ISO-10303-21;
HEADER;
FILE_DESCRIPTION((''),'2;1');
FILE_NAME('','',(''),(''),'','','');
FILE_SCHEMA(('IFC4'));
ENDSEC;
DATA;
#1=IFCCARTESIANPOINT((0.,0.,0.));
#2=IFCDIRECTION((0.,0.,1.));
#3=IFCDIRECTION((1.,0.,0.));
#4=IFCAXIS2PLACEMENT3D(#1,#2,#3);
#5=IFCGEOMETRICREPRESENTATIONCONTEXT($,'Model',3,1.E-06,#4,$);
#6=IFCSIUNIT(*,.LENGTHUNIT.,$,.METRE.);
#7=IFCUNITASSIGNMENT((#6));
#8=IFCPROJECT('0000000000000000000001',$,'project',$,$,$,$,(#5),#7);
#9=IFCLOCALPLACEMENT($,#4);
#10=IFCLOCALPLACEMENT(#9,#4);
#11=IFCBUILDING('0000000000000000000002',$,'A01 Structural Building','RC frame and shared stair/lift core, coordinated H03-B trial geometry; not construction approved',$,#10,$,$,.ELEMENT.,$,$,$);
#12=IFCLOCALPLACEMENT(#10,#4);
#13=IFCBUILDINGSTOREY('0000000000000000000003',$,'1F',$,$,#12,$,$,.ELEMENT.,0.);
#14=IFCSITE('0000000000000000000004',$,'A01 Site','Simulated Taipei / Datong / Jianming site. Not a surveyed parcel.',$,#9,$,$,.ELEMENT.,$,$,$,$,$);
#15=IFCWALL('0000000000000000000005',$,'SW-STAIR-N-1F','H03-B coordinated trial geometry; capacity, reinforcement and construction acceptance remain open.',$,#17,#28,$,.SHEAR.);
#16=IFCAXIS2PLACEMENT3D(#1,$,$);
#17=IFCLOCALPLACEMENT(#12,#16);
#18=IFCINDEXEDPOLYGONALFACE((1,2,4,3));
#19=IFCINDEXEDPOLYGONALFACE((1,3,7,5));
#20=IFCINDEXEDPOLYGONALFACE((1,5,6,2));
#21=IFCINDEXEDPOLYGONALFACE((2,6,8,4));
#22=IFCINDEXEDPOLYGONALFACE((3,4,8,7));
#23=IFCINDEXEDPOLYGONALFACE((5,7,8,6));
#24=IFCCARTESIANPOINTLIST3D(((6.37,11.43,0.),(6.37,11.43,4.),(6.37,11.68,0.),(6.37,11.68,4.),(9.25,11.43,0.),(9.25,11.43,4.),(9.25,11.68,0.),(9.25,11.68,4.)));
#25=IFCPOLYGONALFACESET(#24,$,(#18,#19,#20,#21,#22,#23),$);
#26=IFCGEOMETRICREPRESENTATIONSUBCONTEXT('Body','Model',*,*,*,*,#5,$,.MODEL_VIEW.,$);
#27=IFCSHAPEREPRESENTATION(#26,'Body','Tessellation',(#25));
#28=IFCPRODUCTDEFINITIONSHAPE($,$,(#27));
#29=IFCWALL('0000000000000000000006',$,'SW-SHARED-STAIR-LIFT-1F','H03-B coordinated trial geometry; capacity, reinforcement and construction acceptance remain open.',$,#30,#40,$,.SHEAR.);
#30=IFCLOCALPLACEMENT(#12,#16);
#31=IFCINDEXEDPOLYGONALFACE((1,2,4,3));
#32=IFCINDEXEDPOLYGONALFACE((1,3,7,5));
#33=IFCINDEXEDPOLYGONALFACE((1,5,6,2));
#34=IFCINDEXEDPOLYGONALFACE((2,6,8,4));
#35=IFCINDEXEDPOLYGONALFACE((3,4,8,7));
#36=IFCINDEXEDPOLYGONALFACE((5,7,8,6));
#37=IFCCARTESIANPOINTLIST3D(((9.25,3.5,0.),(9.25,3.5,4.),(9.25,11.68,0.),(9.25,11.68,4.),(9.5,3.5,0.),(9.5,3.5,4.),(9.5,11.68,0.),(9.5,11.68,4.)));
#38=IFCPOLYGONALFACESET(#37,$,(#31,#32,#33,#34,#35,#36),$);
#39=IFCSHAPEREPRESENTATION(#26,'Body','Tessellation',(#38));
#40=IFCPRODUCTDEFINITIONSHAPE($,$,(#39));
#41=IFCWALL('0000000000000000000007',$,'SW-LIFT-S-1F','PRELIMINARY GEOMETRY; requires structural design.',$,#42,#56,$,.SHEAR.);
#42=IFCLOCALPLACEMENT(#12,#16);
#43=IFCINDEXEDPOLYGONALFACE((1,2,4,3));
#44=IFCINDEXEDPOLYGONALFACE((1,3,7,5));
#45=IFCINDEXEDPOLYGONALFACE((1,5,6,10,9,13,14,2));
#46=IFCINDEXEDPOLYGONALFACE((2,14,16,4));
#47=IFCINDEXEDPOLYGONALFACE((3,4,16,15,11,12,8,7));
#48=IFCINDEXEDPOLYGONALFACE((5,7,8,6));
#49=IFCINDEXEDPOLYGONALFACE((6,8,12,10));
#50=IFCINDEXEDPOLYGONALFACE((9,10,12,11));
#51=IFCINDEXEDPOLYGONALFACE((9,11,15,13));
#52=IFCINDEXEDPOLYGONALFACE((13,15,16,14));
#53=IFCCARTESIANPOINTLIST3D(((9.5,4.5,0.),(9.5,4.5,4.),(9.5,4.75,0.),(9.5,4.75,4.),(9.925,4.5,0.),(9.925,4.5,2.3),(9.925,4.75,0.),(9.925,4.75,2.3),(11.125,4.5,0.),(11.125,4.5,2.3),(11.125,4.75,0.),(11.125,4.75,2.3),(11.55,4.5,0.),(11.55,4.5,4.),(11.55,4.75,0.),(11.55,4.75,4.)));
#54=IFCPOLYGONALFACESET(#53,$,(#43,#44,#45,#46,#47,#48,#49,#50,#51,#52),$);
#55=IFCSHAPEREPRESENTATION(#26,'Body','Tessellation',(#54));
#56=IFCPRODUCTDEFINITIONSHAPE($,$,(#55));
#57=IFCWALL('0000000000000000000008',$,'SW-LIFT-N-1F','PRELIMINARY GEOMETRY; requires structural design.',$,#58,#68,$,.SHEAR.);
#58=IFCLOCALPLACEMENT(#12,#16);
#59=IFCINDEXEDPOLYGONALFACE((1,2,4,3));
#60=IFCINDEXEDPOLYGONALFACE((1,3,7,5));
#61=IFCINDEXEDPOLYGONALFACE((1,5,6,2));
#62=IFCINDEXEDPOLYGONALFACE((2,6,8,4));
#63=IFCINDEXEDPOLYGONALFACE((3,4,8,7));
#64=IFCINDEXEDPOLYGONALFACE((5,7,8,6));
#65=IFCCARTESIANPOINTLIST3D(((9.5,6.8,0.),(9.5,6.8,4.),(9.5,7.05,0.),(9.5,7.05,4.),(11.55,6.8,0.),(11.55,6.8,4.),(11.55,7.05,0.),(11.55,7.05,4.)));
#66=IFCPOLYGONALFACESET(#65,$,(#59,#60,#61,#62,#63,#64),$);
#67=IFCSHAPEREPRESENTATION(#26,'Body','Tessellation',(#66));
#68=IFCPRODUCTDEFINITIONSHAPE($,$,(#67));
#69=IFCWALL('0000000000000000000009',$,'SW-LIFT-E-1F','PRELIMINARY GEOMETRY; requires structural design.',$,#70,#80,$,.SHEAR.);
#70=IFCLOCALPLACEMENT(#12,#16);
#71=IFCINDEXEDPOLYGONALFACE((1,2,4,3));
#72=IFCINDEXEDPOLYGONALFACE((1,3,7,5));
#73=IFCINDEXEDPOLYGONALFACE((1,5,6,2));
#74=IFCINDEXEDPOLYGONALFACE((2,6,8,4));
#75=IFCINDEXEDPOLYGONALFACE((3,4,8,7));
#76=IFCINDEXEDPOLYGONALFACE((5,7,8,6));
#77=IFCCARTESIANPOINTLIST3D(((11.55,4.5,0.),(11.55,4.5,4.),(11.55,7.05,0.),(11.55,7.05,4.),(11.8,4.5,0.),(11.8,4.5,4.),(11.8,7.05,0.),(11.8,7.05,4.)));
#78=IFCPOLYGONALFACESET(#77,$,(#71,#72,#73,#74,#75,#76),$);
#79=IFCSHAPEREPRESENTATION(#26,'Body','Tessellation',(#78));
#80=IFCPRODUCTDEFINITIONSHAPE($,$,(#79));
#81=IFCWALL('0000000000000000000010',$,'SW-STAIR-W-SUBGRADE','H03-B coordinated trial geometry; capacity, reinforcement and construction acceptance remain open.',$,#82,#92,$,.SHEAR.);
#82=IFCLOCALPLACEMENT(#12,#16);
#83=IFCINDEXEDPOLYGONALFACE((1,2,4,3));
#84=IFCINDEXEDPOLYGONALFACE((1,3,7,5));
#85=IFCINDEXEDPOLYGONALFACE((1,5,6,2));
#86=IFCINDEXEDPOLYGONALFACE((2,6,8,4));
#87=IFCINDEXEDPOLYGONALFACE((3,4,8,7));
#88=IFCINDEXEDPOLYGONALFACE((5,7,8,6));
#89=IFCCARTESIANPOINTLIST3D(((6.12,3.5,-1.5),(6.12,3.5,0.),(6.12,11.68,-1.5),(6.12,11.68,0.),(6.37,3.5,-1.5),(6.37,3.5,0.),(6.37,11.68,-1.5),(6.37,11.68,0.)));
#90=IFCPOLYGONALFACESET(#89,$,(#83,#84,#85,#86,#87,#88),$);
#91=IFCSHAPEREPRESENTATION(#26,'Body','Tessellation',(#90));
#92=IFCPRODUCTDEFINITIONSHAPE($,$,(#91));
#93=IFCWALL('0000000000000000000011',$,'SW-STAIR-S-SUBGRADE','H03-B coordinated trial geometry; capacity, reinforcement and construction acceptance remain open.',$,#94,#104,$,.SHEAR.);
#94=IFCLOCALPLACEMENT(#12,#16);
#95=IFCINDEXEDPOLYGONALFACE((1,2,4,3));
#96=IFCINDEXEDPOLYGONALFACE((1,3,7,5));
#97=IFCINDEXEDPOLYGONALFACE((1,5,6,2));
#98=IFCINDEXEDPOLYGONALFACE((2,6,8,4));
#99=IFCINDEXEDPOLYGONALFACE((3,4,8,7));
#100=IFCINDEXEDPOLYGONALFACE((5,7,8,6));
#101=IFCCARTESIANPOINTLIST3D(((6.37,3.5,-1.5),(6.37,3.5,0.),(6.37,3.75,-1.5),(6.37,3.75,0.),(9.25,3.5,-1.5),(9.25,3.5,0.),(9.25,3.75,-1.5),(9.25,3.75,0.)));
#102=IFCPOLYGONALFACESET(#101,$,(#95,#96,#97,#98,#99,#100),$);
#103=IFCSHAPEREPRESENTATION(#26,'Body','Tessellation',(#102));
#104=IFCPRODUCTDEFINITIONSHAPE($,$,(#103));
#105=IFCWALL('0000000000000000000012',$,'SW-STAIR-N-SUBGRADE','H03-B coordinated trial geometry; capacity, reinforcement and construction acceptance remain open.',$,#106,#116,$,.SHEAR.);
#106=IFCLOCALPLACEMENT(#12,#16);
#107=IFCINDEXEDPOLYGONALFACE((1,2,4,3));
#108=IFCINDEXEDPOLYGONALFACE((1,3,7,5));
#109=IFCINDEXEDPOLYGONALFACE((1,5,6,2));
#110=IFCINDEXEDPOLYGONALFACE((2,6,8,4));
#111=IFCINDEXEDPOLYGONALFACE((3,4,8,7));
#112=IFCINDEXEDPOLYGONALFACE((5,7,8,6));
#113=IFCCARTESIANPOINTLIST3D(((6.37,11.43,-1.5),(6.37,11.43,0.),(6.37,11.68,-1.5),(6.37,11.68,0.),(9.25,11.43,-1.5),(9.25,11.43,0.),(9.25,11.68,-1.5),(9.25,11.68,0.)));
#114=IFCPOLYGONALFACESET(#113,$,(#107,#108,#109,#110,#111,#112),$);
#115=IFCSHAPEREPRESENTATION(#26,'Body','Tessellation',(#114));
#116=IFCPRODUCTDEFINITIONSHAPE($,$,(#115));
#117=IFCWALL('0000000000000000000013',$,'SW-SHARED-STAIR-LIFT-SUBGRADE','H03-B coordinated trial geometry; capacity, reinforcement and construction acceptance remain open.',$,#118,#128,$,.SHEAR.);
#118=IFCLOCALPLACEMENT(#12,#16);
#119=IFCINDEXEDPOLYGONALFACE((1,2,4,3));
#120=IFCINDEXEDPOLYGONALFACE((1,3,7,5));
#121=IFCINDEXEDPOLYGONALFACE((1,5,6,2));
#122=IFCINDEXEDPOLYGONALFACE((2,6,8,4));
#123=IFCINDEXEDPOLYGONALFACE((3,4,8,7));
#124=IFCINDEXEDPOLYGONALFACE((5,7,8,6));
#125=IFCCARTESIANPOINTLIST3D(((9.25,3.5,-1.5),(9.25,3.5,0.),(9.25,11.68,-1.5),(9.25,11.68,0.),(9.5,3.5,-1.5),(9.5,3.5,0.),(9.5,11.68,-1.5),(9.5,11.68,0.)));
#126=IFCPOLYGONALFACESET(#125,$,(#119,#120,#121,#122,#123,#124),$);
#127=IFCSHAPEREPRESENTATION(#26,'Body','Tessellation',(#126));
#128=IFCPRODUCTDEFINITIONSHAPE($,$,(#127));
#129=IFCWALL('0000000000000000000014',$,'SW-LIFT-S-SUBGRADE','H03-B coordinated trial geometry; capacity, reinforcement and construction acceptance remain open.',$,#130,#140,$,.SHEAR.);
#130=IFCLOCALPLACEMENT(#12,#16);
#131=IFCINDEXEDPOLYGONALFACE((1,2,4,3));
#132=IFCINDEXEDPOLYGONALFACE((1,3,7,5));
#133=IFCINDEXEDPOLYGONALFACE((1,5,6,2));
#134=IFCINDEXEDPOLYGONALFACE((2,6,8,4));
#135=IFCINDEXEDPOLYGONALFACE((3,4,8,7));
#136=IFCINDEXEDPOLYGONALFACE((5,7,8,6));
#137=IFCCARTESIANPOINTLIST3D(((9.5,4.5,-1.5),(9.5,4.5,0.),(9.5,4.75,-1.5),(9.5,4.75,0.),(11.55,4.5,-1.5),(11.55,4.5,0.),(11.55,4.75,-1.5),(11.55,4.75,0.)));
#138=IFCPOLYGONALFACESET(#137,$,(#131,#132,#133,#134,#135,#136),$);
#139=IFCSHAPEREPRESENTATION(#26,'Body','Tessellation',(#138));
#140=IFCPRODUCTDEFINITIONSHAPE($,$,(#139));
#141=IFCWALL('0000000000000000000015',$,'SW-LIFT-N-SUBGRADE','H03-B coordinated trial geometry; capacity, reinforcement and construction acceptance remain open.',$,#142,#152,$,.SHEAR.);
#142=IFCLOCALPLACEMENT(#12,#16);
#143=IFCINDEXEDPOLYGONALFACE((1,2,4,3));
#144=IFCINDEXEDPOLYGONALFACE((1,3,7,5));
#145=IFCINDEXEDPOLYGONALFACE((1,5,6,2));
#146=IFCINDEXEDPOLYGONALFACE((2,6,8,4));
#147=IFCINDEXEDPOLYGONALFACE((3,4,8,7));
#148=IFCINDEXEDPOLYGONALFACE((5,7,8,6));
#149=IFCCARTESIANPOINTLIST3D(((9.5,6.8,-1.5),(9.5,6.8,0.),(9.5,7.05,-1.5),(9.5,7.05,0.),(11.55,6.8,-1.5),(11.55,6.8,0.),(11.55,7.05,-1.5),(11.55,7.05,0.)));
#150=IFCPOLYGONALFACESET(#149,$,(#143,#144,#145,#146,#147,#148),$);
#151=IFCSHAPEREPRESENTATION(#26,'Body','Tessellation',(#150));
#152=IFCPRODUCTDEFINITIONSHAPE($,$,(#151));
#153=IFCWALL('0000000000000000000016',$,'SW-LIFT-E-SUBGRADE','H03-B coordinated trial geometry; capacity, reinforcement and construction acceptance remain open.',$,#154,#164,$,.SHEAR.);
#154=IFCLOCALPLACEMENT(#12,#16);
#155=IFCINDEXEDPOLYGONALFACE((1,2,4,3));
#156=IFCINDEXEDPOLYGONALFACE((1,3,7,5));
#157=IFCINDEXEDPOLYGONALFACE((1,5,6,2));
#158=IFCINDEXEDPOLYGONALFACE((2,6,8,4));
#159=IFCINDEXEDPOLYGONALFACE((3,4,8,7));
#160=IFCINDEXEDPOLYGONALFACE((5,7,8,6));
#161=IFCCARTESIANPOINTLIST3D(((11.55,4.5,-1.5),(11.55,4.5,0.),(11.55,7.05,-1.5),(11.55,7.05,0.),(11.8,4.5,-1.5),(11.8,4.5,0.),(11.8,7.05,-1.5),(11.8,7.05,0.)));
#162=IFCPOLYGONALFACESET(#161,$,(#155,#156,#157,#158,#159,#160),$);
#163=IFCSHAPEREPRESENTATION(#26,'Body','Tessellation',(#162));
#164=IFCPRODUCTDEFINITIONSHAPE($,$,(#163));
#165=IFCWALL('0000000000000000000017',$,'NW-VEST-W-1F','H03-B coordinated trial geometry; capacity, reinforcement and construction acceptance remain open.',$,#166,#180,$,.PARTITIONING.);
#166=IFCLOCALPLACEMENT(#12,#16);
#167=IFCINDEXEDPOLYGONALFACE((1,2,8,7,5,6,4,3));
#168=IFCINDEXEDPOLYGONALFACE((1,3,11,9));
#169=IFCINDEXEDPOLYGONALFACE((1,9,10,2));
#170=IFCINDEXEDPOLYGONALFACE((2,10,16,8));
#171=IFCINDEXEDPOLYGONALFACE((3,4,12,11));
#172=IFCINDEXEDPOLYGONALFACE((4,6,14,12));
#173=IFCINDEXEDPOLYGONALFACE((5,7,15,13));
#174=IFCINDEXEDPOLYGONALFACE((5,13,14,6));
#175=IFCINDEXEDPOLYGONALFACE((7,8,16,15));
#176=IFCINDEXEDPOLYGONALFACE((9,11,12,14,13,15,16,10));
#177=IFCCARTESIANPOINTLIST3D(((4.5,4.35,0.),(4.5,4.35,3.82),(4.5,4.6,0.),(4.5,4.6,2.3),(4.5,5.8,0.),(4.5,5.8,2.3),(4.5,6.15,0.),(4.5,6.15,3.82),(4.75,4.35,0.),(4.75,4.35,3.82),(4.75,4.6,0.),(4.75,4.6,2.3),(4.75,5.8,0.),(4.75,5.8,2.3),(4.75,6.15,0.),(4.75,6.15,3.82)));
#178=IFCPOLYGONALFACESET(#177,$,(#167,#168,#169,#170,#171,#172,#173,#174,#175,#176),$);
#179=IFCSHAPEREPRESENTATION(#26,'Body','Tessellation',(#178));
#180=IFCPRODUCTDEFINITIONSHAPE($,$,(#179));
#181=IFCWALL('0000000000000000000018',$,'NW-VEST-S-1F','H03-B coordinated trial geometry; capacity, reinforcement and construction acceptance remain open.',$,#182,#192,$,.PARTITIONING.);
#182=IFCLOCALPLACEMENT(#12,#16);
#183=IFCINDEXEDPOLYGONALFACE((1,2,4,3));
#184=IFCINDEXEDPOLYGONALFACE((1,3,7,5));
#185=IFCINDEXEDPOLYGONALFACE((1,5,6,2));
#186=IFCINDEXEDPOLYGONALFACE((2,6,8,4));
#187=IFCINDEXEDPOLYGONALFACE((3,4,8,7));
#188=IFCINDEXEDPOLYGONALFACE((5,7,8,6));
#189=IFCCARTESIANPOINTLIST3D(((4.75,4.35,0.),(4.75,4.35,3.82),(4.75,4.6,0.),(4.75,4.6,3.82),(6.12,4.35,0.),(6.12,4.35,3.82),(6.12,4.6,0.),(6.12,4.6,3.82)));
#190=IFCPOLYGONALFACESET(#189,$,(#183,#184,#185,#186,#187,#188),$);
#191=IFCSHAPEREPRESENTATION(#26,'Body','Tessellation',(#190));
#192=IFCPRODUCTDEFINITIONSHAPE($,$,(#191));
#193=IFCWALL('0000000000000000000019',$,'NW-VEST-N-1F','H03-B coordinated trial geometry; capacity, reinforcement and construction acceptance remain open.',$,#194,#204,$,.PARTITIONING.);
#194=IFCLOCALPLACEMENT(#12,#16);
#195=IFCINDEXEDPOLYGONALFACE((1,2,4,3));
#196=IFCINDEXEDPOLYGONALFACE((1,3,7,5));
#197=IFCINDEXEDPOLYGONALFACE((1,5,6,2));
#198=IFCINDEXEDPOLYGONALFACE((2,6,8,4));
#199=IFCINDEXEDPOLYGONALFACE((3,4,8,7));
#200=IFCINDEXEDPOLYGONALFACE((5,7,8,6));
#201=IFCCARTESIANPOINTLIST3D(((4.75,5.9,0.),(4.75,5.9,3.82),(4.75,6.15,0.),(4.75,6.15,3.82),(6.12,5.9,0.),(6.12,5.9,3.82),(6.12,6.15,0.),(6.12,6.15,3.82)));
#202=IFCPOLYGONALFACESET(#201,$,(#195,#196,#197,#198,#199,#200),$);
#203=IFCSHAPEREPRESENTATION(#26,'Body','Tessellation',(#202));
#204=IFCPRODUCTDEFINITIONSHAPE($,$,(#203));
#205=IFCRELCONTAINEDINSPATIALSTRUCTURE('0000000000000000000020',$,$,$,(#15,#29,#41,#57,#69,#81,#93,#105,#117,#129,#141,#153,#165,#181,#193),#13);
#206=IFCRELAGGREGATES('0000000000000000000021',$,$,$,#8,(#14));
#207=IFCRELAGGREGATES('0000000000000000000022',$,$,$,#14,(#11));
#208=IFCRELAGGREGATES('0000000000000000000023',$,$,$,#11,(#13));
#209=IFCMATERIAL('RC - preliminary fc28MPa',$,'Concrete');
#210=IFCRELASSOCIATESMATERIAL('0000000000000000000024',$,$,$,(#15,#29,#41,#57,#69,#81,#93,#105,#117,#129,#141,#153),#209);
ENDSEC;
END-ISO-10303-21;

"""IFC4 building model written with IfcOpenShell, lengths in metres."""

from ifc_helpers import new_model, si_unit, frame, origin_with_axes, place, context, subcontext, project, spatial, polyline, rectangle, outline, extrude, material, element, save


model = new_model("IFC4")

# Units and contexts
model_context = context("Model", 3, precision=1e-06, world=origin_with_axes())
body_context = subcontext(model_context, "Body", "Model", "MODEL_VIEW")
ifc_project = project(units=[si_unit("LENGTHUNIT", "METRE")], contexts=[model_context])

# Site, building, storey
site_placement = place(None, origin_with_axes())
site = spatial("IfcSite", under=ifc_project, at=site_placement, Name="A01 Site", Description="Simulated Taipei / Datong / Jianming site. Not a surveyed parcel.", CompositionType="ELEMENT")
building_placement = place(site_placement, origin_with_axes())
building = spatial("IfcBuilding", under=site, at=building_placement, Name="A01 Structural Building", Description="RC frame and shared stair/lift core, coordinated H03-B trial geometry; not construction approved", CompositionType="ELEMENT")
storey_placement = place(building_placement, origin_with_axes())
storey = spatial("IfcBuildingStorey", under=building, at=storey_placement, Name="1F", CompositionType="ELEMENT", Elevation=0.0)

# Shared definitions
ifc_material = material(Name="RC - preliminary fc28MPa", Category="Concrete")

# Shared definitions
placement = place(None, origin_with_axes())

# Walls
element("IfcWall", 1, at=placement, inside=storey, material=ifc_material, Name="SW-STAIR-N-1F", Description="H03-B coordinated trial geometry; capacity, reinforcement and construction acceptance remain open.", PredefinedType="SHEAR", context=body_context, shape_type="SweptSolid", body=[
    extrude(outline(polyline([(9.25, 11.43), (9.25, 11.68), (6.37, 11.68), (6.37, 11.43), (9.25, 11.43)])), origin_with_axes(), (0.0, 0.0, 1.0), 4.0),
])
element("IfcWall", 2, at=placement, inside=storey, material=ifc_material, Name="SW-SHARED-STAIR-LIFT-1F", Description="H03-B coordinated trial geometry; capacity, reinforcement and construction acceptance remain open.", PredefinedType="SHEAR", context=body_context, shape_type="SweptSolid", body=[
    extrude(outline(polyline([(9.5, 3.5), (9.5, 11.68), (9.25, 11.68), (9.25, 3.5), (9.5, 3.5)])), origin_with_axes(), (0.0, 0.0, 1.0), 4.0),
])

# Wall, opening
wall_1_placement = place(storey_placement, frame((10.525, 4.625, 0.0), z_axis=(0.0, 0.0, 1.0), x_axis=(1.0, 0.0, 0.0)))
wall_1 = element("IfcWall", 3, at=wall_1_placement, inside=storey, material=ifc_material, Name="SW-LIFT-S-1F", Description="PRELIMINARY GEOMETRY; requires structural design.", PredefinedType="SHEAR", context=body_context, shape_type="SweptSolid", body=[
    extrude(rectangle(XDim=2.05, YDim=0.25), origin_with_axes(), (0.0, 0.0, 1.0), 4.0),
])
opening_1_placement = place(storey_placement, frame((10.525, 4.625, 0.0), z_axis=(0.0, 0.0, 1.0), x_axis=(1.0, 0.0, 0.0)))
element("IfcOpeningElement", 4, at=opening_1_placement, cuts=wall_1, PredefinedType="OPENING", context=body_context, shape_type="SweptSolid", body=[
    extrude(rectangle(XDim=1.2, YDim=0.45), origin_with_axes(), (0.0, 0.0, 1.0), 2.3),
])

# Walls
wall_2_placement = place(storey_placement, frame((10.525, 6.925, 0.0), z_axis=(0.0, 0.0, 1.0), x_axis=(1.0, 0.0, 0.0)))
element("IfcWall", 5, at=wall_2_placement, inside=storey, material=ifc_material, Name="SW-LIFT-N-1F", Description="PRELIMINARY GEOMETRY; requires structural design.", PredefinedType="SHEAR", context=body_context, shape_type="SweptSolid", body=[
    extrude(rectangle(XDim=2.05, YDim=0.25), origin_with_axes(), (0.0, 0.0, 1.0), 4.0),
])
wall_3_placement = place(storey_placement, frame((11.675, 5.775, 0.0), z_axis=(0.0, 0.0, 1.0), x_axis=(1.0, 0.0, 0.0)))
element("IfcWall", 6, at=wall_3_placement, inside=storey, material=ifc_material, Name="SW-LIFT-E-1F", Description="PRELIMINARY GEOMETRY; requires structural design.", PredefinedType="SHEAR", context=body_context, shape_type="SweptSolid", body=[
    extrude(rectangle(XDim=0.25, YDim=2.55), origin_with_axes(), (0.0, 0.0, 1.0), 4.0),
])
element("IfcWall", 7, at=placement, inside=storey, material=ifc_material, Name="SW-STAIR-W-SUBGRADE", Description="H03-B coordinated trial geometry; capacity, reinforcement and construction acceptance remain open.", PredefinedType="SHEAR", context=body_context, shape_type="SweptSolid", body=[
    extrude(outline(polyline([(6.37, 3.5), (6.37, 11.68), (6.12, 11.68), (6.12, 3.5), (6.37, 3.5)])), frame((0.0, 0.0, -1.5), z_axis=(0.0, 0.0, 1.0), x_axis=(1.0, 0.0, 0.0)), (0.0, 0.0, 1.0), 1.5),
])
element("IfcWall", 8, at=placement, inside=storey, material=ifc_material, Name="SW-STAIR-S-SUBGRADE", Description="H03-B coordinated trial geometry; capacity, reinforcement and construction acceptance remain open.", PredefinedType="SHEAR", context=body_context, shape_type="SweptSolid", body=[
    extrude(outline(polyline([(9.25, 3.5), (9.25, 3.75), (6.37, 3.75), (6.37, 3.5), (9.25, 3.5)])), frame((0.0, 0.0, -1.5), z_axis=(0.0, 0.0, 1.0), x_axis=(1.0, 0.0, 0.0)), (0.0, 0.0, 1.0), 1.5),
])
element("IfcWall", 9, at=placement, inside=storey, material=ifc_material, Name="SW-STAIR-N-SUBGRADE", Description="H03-B coordinated trial geometry; capacity, reinforcement and construction acceptance remain open.", PredefinedType="SHEAR", context=body_context, shape_type="SweptSolid", body=[
    extrude(outline(polyline([(9.25, 11.43), (9.25, 11.68), (6.37, 11.68), (6.37, 11.43), (9.25, 11.43)])), frame((0.0, 0.0, -1.5), z_axis=(0.0, 0.0, 1.0), x_axis=(1.0, 0.0, 0.0)), (0.0, 0.0, 1.0), 1.5),
])
element("IfcWall", 10, at=placement, inside=storey, material=ifc_material, Name="SW-SHARED-STAIR-LIFT-SUBGRADE", Description="H03-B coordinated trial geometry; capacity, reinforcement and construction acceptance remain open.", PredefinedType="SHEAR", context=body_context, shape_type="SweptSolid", body=[
    extrude(outline(polyline([(9.5, 3.5), (9.5, 11.68), (9.25, 11.68), (9.25, 3.5), (9.5, 3.5)])), frame((0.0, 0.0, -1.5), z_axis=(0.0, 0.0, 1.0), x_axis=(1.0, 0.0, 0.0)), (0.0, 0.0, 1.0), 1.5),
])
element("IfcWall", 11, at=placement, inside=storey, material=ifc_material, Name="SW-LIFT-S-SUBGRADE", Description="H03-B coordinated trial geometry; capacity, reinforcement and construction acceptance remain open.", PredefinedType="SHEAR", context=body_context, shape_type="SweptSolid", body=[
    extrude(outline(polyline([(11.55, 4.5), (11.55, 4.75), (9.5, 4.75), (9.5, 4.5), (11.55, 4.5)])), frame((0.0, 0.0, -1.5), z_axis=(0.0, 0.0, 1.0), x_axis=(1.0, 0.0, 0.0)), (0.0, 0.0, 1.0), 1.5),
])
element("IfcWall", 12, at=placement, inside=storey, material=ifc_material, Name="SW-LIFT-N-SUBGRADE", Description="H03-B coordinated trial geometry; capacity, reinforcement and construction acceptance remain open.", PredefinedType="SHEAR", context=body_context, shape_type="SweptSolid", body=[
    extrude(outline(polyline([(11.55, 6.8), (11.55, 7.05), (9.5, 7.05), (9.5, 6.8), (11.55, 6.8)])), frame((0.0, 0.0, -1.5), z_axis=(0.0, 0.0, 1.0), x_axis=(1.0, 0.0, 0.0)), (0.0, 0.0, 1.0), 1.5),
])
element("IfcWall", 13, at=placement, inside=storey, material=ifc_material, Name="SW-LIFT-E-SUBGRADE", Description="H03-B coordinated trial geometry; capacity, reinforcement and construction acceptance remain open.", PredefinedType="SHEAR", context=body_context, shape_type="SweptSolid", body=[
    extrude(outline(polyline([(11.8, 4.5), (11.8, 7.05), (11.55, 7.05), (11.55, 4.5), (11.8, 4.5)])), frame((0.0, 0.0, -1.5), z_axis=(0.0, 0.0, 1.0), x_axis=(1.0, 0.0, 0.0)), (0.0, 0.0, 1.0), 1.5),
])

# Wall, opening
wall_4 = element("IfcWall", 14, at=placement, inside=storey, Name="NW-VEST-W-1F", Description="H03-B coordinated trial geometry; capacity, reinforcement and construction acceptance remain open.", PredefinedType="PARTITIONING", context=body_context, shape_type="SweptSolid", body=[
    extrude(outline(polyline([(4.75, 4.35), (4.75, 6.15), (4.5, 6.15), (4.5, 4.35), (4.75, 4.35)])), origin_with_axes(), (0.0, 0.0, 1.0), 3.82),
])
element("IfcOpeningElement", 15, at=placement, cuts=wall_4, PredefinedType="OPENING", context=body_context, shape_type="SweptSolid", body=[
    extrude(outline(polyline([(4.8, 4.6), (4.8, 5.8), (4.45, 5.8), (4.45, 4.6), (4.8, 4.6)])), origin_with_axes(), (0.0, 0.0, 1.0), 2.3),
])

# Walls
element("IfcWall", 16, at=placement, inside=storey, Name="NW-VEST-S-1F", Description="H03-B coordinated trial geometry; capacity, reinforcement and construction acceptance remain open.", PredefinedType="PARTITIONING", context=body_context, shape_type="SweptSolid", body=[
    extrude(outline(polyline([(6.12, 4.35), (6.12, 4.6), (4.75, 4.6), (4.75, 4.35), (6.12, 4.35)])), origin_with_axes(), (0.0, 0.0, 1.0), 3.82),
])
element("IfcWall", 17, at=placement, inside=storey, Name="NW-VEST-N-1F", Description="H03-B coordinated trial geometry; capacity, reinforcement and construction acceptance remain open.", PredefinedType="PARTITIONING", context=body_context, shape_type="SweptSolid", body=[
    extrude(outline(polyline([(6.12, 5.9), (6.12, 6.15), (4.75, 6.15), (4.75, 5.9), (6.12, 5.9)])), origin_with_axes(), (0.0, 0.0, 1.0), 3.82),
])

save(model, "model.ifc")
